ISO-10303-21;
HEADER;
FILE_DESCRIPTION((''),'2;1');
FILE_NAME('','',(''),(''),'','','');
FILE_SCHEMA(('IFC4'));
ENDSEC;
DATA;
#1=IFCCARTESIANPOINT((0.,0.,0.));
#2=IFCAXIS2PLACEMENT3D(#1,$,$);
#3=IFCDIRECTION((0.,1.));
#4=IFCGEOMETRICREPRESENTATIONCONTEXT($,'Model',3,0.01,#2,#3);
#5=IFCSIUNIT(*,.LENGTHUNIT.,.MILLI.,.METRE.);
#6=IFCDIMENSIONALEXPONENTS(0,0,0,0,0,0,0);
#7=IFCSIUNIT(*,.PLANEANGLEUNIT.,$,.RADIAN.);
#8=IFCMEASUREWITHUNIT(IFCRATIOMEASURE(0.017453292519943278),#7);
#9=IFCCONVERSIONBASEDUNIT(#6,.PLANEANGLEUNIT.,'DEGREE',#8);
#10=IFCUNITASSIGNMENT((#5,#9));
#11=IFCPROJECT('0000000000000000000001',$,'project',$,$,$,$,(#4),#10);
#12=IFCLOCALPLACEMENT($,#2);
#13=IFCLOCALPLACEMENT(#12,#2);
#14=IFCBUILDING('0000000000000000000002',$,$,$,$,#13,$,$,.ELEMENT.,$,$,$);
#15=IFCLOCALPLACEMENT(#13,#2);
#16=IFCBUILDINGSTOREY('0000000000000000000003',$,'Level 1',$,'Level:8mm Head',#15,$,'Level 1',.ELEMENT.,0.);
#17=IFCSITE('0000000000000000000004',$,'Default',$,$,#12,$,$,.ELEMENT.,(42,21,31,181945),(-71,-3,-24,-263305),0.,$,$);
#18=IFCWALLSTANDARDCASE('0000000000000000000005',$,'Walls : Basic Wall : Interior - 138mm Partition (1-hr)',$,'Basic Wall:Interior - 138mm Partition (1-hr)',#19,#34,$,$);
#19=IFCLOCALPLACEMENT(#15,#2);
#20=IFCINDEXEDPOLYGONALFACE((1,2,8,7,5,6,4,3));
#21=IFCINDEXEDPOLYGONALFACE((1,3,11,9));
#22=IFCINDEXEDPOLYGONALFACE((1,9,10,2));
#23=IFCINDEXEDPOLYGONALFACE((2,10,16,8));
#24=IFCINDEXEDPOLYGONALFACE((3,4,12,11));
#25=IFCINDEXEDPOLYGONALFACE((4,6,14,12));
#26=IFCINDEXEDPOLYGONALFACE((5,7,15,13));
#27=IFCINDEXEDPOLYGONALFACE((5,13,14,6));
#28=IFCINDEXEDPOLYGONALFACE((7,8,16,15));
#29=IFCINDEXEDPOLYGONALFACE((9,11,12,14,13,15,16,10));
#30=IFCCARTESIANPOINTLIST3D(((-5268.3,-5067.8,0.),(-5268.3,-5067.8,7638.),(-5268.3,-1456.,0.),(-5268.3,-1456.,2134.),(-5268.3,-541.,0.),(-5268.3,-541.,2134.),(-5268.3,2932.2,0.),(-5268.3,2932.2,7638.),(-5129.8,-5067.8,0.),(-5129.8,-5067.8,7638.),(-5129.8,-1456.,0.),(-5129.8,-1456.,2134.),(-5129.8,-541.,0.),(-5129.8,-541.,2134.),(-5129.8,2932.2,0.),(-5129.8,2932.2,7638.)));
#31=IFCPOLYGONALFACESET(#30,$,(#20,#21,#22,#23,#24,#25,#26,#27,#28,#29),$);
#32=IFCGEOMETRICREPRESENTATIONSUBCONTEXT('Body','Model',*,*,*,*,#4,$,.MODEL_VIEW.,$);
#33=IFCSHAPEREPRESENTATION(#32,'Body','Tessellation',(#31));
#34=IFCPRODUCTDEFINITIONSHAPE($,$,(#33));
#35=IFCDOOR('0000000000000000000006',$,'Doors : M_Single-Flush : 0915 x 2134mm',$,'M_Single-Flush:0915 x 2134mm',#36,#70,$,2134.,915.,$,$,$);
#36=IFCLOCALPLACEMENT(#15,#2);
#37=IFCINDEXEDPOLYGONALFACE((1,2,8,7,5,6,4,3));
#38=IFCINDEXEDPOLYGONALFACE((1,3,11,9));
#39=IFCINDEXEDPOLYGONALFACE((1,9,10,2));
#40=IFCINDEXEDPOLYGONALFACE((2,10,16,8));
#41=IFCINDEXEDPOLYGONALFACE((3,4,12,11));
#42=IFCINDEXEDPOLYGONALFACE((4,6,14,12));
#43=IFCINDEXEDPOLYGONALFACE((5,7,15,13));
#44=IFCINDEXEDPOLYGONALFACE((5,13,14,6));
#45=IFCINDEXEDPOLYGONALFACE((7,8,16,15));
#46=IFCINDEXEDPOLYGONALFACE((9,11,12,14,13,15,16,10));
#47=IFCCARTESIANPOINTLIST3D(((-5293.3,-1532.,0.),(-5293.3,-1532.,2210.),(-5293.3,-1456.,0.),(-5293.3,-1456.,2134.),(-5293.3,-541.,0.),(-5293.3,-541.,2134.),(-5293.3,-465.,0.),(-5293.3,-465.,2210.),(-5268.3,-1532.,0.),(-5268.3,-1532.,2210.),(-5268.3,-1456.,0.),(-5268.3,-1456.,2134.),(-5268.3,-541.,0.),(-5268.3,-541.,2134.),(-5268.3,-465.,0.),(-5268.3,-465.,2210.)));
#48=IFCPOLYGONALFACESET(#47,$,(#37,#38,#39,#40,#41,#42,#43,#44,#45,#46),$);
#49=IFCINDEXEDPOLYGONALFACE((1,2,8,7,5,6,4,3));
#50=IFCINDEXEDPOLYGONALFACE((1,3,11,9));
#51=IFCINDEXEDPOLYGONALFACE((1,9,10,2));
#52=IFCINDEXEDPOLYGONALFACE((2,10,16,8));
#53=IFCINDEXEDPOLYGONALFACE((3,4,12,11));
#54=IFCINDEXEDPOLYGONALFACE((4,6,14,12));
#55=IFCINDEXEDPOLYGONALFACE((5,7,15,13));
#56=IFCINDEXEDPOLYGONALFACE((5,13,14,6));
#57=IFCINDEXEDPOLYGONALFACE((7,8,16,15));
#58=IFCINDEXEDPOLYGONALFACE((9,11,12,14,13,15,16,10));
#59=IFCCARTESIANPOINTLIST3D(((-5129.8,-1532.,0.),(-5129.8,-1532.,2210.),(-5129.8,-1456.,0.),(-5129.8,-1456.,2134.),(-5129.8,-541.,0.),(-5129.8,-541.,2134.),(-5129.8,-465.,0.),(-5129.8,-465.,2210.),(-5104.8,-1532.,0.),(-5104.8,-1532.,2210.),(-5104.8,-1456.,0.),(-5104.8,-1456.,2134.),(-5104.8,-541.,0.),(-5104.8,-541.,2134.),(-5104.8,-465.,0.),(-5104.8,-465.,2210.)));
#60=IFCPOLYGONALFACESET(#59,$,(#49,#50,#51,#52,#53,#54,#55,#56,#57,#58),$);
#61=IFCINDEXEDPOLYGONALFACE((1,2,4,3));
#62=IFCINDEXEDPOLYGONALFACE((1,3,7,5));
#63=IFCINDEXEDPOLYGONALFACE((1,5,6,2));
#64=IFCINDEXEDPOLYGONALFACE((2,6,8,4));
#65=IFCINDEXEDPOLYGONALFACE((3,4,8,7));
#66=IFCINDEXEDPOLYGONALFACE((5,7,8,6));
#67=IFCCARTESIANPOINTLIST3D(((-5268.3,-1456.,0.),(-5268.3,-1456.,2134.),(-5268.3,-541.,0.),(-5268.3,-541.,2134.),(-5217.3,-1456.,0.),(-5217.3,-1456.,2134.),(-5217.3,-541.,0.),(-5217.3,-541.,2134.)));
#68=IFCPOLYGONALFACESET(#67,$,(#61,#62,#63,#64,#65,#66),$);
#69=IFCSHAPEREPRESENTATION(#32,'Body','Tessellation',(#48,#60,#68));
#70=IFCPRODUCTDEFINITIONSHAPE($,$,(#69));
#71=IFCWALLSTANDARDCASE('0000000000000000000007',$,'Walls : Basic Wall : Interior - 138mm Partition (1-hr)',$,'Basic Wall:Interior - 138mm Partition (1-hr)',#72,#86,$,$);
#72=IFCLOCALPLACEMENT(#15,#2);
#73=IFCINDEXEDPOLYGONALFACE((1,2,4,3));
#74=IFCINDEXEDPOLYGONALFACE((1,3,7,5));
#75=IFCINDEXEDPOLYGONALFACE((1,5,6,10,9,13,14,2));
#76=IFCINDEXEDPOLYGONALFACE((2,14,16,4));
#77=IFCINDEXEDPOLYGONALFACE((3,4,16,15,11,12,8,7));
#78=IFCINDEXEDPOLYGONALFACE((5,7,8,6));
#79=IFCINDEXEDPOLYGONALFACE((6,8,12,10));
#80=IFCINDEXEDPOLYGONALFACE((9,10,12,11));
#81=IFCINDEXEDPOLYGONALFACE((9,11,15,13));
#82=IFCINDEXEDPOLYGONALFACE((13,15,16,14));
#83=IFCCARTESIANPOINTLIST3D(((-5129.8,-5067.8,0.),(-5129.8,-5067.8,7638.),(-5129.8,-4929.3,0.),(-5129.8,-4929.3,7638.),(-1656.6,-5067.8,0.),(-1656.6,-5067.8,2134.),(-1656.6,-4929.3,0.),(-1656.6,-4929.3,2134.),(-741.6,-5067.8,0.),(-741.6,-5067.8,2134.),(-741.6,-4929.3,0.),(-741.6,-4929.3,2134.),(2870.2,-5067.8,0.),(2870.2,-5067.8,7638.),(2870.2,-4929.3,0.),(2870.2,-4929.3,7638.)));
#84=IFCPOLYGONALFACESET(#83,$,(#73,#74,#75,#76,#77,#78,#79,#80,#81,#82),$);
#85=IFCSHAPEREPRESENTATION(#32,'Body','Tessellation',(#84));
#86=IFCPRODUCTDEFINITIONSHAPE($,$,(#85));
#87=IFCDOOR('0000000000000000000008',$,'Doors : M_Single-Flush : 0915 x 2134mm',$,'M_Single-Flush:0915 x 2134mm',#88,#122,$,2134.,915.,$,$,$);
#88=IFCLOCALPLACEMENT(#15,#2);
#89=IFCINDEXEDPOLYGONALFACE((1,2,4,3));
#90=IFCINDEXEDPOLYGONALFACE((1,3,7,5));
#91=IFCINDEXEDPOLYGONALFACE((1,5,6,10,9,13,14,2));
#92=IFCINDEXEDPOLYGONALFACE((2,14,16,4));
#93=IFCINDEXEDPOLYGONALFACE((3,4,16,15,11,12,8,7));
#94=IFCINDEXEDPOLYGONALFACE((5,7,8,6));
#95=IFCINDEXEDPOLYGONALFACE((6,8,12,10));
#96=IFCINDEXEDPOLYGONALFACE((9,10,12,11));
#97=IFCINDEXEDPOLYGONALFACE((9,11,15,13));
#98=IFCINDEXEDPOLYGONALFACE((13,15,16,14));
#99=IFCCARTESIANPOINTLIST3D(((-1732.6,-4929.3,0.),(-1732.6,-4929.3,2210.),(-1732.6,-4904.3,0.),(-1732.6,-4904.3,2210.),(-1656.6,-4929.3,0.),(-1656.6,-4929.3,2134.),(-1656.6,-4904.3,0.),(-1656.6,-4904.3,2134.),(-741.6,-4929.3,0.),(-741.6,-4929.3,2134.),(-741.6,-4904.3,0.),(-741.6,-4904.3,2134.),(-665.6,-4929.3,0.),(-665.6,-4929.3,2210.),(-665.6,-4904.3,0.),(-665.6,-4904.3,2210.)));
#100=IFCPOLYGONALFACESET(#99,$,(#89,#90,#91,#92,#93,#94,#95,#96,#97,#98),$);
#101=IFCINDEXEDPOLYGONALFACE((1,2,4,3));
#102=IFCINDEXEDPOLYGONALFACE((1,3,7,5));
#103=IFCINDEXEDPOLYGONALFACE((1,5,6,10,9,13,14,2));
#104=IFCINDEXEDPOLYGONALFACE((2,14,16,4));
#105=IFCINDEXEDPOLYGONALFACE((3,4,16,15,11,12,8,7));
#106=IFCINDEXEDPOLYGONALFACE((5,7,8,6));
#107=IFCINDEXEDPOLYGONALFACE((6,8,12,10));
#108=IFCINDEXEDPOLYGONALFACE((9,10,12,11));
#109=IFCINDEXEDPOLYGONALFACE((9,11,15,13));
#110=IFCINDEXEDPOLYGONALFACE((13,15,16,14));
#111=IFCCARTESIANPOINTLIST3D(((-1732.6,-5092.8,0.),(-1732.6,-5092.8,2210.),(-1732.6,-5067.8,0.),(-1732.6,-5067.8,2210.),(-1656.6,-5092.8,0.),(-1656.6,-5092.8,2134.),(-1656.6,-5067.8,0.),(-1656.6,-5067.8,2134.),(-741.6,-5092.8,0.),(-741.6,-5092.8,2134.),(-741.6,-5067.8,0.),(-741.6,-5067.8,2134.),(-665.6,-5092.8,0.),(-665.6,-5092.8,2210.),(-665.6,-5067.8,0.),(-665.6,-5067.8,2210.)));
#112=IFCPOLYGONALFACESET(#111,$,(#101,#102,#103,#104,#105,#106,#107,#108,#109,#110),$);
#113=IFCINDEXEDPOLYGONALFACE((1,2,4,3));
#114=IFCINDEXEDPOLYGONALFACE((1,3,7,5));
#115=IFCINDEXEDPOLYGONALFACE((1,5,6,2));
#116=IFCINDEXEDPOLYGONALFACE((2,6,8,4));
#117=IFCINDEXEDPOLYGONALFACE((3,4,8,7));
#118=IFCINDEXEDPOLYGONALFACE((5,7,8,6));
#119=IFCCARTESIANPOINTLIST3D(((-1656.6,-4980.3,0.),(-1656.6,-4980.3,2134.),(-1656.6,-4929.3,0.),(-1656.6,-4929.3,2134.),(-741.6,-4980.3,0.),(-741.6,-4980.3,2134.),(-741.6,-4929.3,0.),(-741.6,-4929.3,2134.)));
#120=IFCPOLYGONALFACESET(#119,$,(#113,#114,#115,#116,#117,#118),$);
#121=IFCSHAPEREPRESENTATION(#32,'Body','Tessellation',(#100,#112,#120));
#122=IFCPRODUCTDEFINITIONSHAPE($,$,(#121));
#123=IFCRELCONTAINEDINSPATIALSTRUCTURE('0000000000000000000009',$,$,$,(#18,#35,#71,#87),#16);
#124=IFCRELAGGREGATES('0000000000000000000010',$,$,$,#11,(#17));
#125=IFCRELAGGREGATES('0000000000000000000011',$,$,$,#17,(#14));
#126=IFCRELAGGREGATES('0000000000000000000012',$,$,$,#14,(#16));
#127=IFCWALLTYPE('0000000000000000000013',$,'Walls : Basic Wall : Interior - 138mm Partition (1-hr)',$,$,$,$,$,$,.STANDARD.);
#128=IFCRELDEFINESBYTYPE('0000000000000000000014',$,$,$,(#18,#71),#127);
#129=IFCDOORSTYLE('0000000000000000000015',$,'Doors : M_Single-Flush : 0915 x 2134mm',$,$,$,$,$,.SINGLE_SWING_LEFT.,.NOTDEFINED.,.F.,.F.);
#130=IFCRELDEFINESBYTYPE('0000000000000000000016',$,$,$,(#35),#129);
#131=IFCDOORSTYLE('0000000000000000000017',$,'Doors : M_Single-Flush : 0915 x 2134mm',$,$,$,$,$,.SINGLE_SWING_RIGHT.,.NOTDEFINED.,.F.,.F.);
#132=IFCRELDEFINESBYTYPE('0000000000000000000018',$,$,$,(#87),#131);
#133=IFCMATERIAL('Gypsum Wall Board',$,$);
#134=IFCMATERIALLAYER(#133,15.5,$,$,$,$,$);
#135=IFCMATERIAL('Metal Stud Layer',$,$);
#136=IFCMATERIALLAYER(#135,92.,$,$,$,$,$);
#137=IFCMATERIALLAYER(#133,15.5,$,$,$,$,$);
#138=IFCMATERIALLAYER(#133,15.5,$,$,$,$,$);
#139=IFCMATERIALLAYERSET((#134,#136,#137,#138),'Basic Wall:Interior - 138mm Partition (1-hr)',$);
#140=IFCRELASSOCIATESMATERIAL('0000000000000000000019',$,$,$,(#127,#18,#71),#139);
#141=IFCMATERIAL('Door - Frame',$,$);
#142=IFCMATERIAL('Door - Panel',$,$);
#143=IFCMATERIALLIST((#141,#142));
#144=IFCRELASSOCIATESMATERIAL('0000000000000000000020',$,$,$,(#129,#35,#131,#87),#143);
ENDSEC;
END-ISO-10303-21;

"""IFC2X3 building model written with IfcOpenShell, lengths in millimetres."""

from ifc_helpers import new_model, entity, si_unit, converted_unit, direction, frame, frame_2d, origin, place, context, subcontext, project, spatial, polyline, rectangle, outline, extrude, clip, bounded_halfspace, source, transform, mapped, material, material_list, layer, layer_set, layer_usage, type_object, type_shapes, element, fill, save


model = new_model("IFC2X3")

# Units and contexts
model_context = context("Model", 3, precision=0.01, world=origin(), true_north=direction((0.0, 1.0)))
body_context = subcontext(model_context, "Body", "Model", "MODEL_VIEW")
ifc_project = project(units=[si_unit("LENGTHUNIT", "METRE", prefix="MILLI"), converted_unit("PLANEANGLEUNIT", "DEGREE", entity("IfcRatioMeasure", 0.017453292519943278), si_unit("PLANEANGLEUNIT", "RADIAN"), dimensions=[0, 0, 0, 0, 0, 0, 0])], contexts=[model_context])

# Site, building, storey
site_placement = place(None, origin())
site = spatial("IfcSite", under=ifc_project, at=site_placement, Name="Default", CompositionType="ELEMENT", RefLatitude=(42, 21, 31, 181945), RefLongitude=(-71, -3, -24, -263305), RefElevation=0.0)
building_placement = place(site_placement, origin())
building = spatial("IfcBuilding", under=site, at=building_placement, CompositionType="ELEMENT")
storey_placement = place(building_placement, origin())
storey = spatial("IfcBuildingStorey", under=building, at=storey_placement, Name="Level 1", ObjectType="Level:8mm Head", LongName="Level 1", CompositionType="ELEMENT", Elevation=0.0)

# Shared definitions
ifc_material_1 = material(Name="Metal Stud Layer")
ifc_material_2 = material(Name="Gypsum Wall Board")

# Shared definitions
ifc_material_3 = material(Name="Door - Frame")
ifc_material_4 = material(Name="Door - Panel")
ifc_material_list = material_list([ifc_material_3, ifc_material_4])

# Shared definitions
ifc_layer_1 = layer(ifc_material_2, 15.5)
ifc_layer_2 = layer(ifc_material_1, 92.0)
ifc_layer_3 = layer(ifc_material_2, 15.5)
ifc_layer_4 = layer(ifc_material_2, 15.5)
ifc_layer_set_1 = layer_set([ifc_layer_1, ifc_layer_2, ifc_layer_3, ifc_layer_4], Name="Basic Wall:Interior - 138mm Partition (1-hr)")
wall_type_1 = type_object("IfcWallType", Name="Walls : Basic Wall : Interior - 138mm Partition (1-hr)", PredefinedType="STANDARD", material=ifc_layer_set_1)

# Walls, openings, doors
ifc_layer_usage_1 = layer_usage(ifc_layer_set_1, "AXIS2", "NEGATIVE", 69.2)
wall_1_placement = place(storey_placement, frame((-5199.1, 2932.2, 0.0), z_axis=(0.0, 0.0, 1.0), x_axis=(0.0, -1.0, 0.0)))
wall_1 = element("IfcWallStandardCase", 1, at=wall_1_placement, inside=storey, type_object=wall_type_1, material=ifc_layer_usage_1, Name="Walls : Basic Wall : Interior - 138mm Partition (1-hr)", ObjectType="Basic Wall:Interior - 138mm Partition (1-hr)", context=body_context, shape_type="Clipping", body=[
    clip(extrude(rectangle(XDim=8000.0, YDim=138.5, at=frame_2d((4000.0, 0.0), x_axis=(-1.0, 0.0))), origin(), (0.0, 0.0, 1.0), 7638.0), bounded_halfspace(frame((0.0, -69.2, 7638.0), z_axis=(0.0, 0.0, -1.0), x_axis=(1.0, 0.0, 0.0)), True, frame((0.0, -69.2, 7638.0)), polyline([(0.0, 0.0), (2438400.0, 0.0), (2438400.0, 42214.8), (2396185.2, 42214.8), (0.0, 42214.8), (0.0, 0.0)]))),
])
opening_1_placement = place(wall_1_placement, frame((4388.2, 69.3, 0.0)))
opening_1 = element("IfcOpeningElement", 2, at=opening_1_placement, cuts=wall_1, ObjectType="Opening", context=body_context, shape_type="SweptSolid", body=[
    extrude(rectangle(XDim=915.0, YDim=2134.0, at=frame_2d((1067.0, 457.5), x_axis=(0.0, -1.0))), frame((0.0, 0.0, 0.0), z_axis=(0.0, -1.0, 0.0), x_axis=(0.0, 0.0, 1.0)), (0.0, 0.0, 1.0), 138.5),
])
door_style_1 = type_object("IfcDoorStyle", Name="Doors : M_Single-Flush : 0915 x 2134mm", ConstructionType="NOTDEFINED", OperationType="SINGLE_SWING_LEFT", ParameterTakesPrecedence=False, Sizeable=False, material=ifc_material_list)
shared_shape_1 = source(origin(), body_context, "Body", "SweptSolid", [
    extrude(outline(polyline([(-533.5, -1124.0), (533.5, -1124.0), (533.5, 1086.0), (457.5, 1086.0), (457.5, -1048.0), (-457.5, -1048.0), (-457.5, 1086.0), (-533.5, 1086.0), (-533.5, -1124.0)])), frame((457.5, 163.5, 1086.0), z_axis=(0.0, -1.0, 0.0), x_axis=(-1.0, 0.0, 0.0)), (0.0, 0.0, 1.0), 25.0),
    extrude(outline(polyline([(-1124.0, -533.5), (1086.0, -533.5), (1086.0, -457.5), (-1048.0, -457.5), (-1048.0, 457.5), (1086.0, 457.5), (1086.0, 533.5), (-1124.0, 533.5), (-1124.0, -533.5)])), frame((457.5, 0.0, 1086.0), z_axis=(0.0, -1.0, 0.0), x_axis=(0.0, 0.0, -1.0)), (0.0, 0.0, 1.0), 25.0),
    extrude(rectangle(XDim=915.0, YDim=51.0, at=frame_2d((0.0, 0.0), x_axis=(1.0, 0.0))), frame((457.5, 113.0, 0.0)), (0.0, 0.0, 1.0), 2134.0),
])
type_shapes(door_style_1, [shared_shape_1])
door_1_placement = place(opening_1_placement, frame((0.0, 0.0, 0.0), z_axis=(0.0, 0.0, 1.0), x_axis=(-1.0, 0.0, 0.0)))
door_1 = element("IfcDoor", 3, at=door_1_placement, inside=storey, type_object=door_style_1, material=ifc_material_list, Name="Doors : M_Single-Flush : 0915 x 2134mm", ObjectType="M_Single-Flush:0915 x 2134mm", OverallHeight=2134.0, OverallWidth=915.0, context=body_context, shape_type="MappedRepresentation", body=[
    mapped(shared_shape_1, transform((0.0, 0.0, 0.0), scale=1.0)),
])
fill(opening_1, door_1)
wall_2_placement = place(storey_placement, frame((-5129.8, -4998.5, 0.0)))
wall_2 = element("IfcWallStandardCase", 4, at=wall_2_placement, inside=storey, type_object=wall_type_1, material=ifc_layer_usage_1, Name="Walls : Basic Wall : Interior - 138mm Partition (1-hr)", ObjectType="Basic Wall:Interior - 138mm Partition (1-hr)", context=body_context, shape_type="Clipping", body=[
    clip(extrude(rectangle(XDim=8000.0, YDim=138.5, at=frame_2d((4000.0, 0.0), x_axis=(-1.0, 0.0))), origin(), (0.0, 0.0, 1.0), 7638.0), bounded_halfspace(frame((0.0, -69.2, 7638.0), z_axis=(0.0, 0.0, -1.0), x_axis=(0.0, -1.0, 0.0)), True, frame((0.0, -69.2, 7638.0)), polyline([(0.0, 0.0), (2396185.2, 0.0), (2438400.0, 0.0), (2438400.0, 42214.8), (0.0, 42214.8), (0.0, 0.0)]))),
])
opening_2_placement = place(wall_2_placement, frame((3473.2, -69.3, 0.0)))
opening_2 = element("IfcOpeningElement", 5, at=opening_2_placement, cuts=wall_2, ObjectType="Opening", context=body_context, shape_type="SweptSolid", body=[
    extrude(rectangle(XDim=915.0, YDim=2134.0, at=frame_2d((1067.0, 457.5), x_axis=(0.0, 1.0))), frame((0.0, 0.0, 0.0), z_axis=(0.0, 1.0, 0.0), x_axis=(0.0, 0.0, 1.0)), (0.0, 0.0, 1.0), 138.5),
])
door_style_2 = type_object("IfcDoorStyle", Name="Doors : M_Single-Flush : 0915 x 2134mm", ConstructionType="NOTDEFINED", OperationType="SINGLE_SWING_RIGHT", ParameterTakesPrecedence=False, Sizeable=False, material=ifc_material_list)
shared_shape_2 = source(origin(), body_context, "Body", "SweptSolid", [
    extrude(outline(polyline([(-533.5, -1124.0), (533.5, -1124.0), (533.5, 1086.0), (457.5, 1086.0), (457.5, -1048.0), (-457.5, -1048.0), (-457.5, 1086.0), (-533.5, 1086.0), (-533.5, -1124.0)])), frame((457.5, 138.5, 1086.0), z_axis=(0.0, 1.0, 0.0), x_axis=(1.0, 0.0, 0.0)), (0.0, 0.0, 1.0), 25.0),
    extrude(outline(polyline([(-1124.0, -533.5), (1086.0, -533.5), (1086.0, -457.5), (-1048.0, -457.5), (-1048.0, 457.5), (1086.0, 457.5), (1086.0, 533.5), (-1124.0, 533.5), (-1124.0, -533.5)])), frame((457.5, -25.0, 1086.0), z_axis=(0.0, 1.0, 0.0), x_axis=(0.0, 0.0, -1.0)), (0.0, 0.0, 1.0), 25.0),
    extrude(rectangle(XDim=51.0, YDim=915.0, at=frame_2d((0.0, 0.0), x_axis=(1.0, 0.0))), frame((457.5, 113.0, 0.0), z_axis=(0.0, 0.0, 1.0), x_axis=(0.0, 1.0, 0.0)), (0.0, 0.0, 1.0), 2134.0),
])
type_shapes(door_style_2, [shared_shape_2])
door_2_placement = place(opening_2_placement, origin())
door_2 = element("IfcDoor", 6, at=door_2_placement, inside=storey, type_object=door_style_2, material=ifc_material_list, Name="Doors : M_Single-Flush : 0915 x 2134mm", ObjectType="M_Single-Flush:0915 x 2134mm", OverallHeight=2134.0, OverallWidth=915.0, context=body_context, shape_type="MappedRepresentation", body=[
    mapped(shared_shape_2, transform((0.0, 0.0, 0.0), scale=1.0)),
])
fill(opening_2, door_2)

save(model, "model.ifc")
